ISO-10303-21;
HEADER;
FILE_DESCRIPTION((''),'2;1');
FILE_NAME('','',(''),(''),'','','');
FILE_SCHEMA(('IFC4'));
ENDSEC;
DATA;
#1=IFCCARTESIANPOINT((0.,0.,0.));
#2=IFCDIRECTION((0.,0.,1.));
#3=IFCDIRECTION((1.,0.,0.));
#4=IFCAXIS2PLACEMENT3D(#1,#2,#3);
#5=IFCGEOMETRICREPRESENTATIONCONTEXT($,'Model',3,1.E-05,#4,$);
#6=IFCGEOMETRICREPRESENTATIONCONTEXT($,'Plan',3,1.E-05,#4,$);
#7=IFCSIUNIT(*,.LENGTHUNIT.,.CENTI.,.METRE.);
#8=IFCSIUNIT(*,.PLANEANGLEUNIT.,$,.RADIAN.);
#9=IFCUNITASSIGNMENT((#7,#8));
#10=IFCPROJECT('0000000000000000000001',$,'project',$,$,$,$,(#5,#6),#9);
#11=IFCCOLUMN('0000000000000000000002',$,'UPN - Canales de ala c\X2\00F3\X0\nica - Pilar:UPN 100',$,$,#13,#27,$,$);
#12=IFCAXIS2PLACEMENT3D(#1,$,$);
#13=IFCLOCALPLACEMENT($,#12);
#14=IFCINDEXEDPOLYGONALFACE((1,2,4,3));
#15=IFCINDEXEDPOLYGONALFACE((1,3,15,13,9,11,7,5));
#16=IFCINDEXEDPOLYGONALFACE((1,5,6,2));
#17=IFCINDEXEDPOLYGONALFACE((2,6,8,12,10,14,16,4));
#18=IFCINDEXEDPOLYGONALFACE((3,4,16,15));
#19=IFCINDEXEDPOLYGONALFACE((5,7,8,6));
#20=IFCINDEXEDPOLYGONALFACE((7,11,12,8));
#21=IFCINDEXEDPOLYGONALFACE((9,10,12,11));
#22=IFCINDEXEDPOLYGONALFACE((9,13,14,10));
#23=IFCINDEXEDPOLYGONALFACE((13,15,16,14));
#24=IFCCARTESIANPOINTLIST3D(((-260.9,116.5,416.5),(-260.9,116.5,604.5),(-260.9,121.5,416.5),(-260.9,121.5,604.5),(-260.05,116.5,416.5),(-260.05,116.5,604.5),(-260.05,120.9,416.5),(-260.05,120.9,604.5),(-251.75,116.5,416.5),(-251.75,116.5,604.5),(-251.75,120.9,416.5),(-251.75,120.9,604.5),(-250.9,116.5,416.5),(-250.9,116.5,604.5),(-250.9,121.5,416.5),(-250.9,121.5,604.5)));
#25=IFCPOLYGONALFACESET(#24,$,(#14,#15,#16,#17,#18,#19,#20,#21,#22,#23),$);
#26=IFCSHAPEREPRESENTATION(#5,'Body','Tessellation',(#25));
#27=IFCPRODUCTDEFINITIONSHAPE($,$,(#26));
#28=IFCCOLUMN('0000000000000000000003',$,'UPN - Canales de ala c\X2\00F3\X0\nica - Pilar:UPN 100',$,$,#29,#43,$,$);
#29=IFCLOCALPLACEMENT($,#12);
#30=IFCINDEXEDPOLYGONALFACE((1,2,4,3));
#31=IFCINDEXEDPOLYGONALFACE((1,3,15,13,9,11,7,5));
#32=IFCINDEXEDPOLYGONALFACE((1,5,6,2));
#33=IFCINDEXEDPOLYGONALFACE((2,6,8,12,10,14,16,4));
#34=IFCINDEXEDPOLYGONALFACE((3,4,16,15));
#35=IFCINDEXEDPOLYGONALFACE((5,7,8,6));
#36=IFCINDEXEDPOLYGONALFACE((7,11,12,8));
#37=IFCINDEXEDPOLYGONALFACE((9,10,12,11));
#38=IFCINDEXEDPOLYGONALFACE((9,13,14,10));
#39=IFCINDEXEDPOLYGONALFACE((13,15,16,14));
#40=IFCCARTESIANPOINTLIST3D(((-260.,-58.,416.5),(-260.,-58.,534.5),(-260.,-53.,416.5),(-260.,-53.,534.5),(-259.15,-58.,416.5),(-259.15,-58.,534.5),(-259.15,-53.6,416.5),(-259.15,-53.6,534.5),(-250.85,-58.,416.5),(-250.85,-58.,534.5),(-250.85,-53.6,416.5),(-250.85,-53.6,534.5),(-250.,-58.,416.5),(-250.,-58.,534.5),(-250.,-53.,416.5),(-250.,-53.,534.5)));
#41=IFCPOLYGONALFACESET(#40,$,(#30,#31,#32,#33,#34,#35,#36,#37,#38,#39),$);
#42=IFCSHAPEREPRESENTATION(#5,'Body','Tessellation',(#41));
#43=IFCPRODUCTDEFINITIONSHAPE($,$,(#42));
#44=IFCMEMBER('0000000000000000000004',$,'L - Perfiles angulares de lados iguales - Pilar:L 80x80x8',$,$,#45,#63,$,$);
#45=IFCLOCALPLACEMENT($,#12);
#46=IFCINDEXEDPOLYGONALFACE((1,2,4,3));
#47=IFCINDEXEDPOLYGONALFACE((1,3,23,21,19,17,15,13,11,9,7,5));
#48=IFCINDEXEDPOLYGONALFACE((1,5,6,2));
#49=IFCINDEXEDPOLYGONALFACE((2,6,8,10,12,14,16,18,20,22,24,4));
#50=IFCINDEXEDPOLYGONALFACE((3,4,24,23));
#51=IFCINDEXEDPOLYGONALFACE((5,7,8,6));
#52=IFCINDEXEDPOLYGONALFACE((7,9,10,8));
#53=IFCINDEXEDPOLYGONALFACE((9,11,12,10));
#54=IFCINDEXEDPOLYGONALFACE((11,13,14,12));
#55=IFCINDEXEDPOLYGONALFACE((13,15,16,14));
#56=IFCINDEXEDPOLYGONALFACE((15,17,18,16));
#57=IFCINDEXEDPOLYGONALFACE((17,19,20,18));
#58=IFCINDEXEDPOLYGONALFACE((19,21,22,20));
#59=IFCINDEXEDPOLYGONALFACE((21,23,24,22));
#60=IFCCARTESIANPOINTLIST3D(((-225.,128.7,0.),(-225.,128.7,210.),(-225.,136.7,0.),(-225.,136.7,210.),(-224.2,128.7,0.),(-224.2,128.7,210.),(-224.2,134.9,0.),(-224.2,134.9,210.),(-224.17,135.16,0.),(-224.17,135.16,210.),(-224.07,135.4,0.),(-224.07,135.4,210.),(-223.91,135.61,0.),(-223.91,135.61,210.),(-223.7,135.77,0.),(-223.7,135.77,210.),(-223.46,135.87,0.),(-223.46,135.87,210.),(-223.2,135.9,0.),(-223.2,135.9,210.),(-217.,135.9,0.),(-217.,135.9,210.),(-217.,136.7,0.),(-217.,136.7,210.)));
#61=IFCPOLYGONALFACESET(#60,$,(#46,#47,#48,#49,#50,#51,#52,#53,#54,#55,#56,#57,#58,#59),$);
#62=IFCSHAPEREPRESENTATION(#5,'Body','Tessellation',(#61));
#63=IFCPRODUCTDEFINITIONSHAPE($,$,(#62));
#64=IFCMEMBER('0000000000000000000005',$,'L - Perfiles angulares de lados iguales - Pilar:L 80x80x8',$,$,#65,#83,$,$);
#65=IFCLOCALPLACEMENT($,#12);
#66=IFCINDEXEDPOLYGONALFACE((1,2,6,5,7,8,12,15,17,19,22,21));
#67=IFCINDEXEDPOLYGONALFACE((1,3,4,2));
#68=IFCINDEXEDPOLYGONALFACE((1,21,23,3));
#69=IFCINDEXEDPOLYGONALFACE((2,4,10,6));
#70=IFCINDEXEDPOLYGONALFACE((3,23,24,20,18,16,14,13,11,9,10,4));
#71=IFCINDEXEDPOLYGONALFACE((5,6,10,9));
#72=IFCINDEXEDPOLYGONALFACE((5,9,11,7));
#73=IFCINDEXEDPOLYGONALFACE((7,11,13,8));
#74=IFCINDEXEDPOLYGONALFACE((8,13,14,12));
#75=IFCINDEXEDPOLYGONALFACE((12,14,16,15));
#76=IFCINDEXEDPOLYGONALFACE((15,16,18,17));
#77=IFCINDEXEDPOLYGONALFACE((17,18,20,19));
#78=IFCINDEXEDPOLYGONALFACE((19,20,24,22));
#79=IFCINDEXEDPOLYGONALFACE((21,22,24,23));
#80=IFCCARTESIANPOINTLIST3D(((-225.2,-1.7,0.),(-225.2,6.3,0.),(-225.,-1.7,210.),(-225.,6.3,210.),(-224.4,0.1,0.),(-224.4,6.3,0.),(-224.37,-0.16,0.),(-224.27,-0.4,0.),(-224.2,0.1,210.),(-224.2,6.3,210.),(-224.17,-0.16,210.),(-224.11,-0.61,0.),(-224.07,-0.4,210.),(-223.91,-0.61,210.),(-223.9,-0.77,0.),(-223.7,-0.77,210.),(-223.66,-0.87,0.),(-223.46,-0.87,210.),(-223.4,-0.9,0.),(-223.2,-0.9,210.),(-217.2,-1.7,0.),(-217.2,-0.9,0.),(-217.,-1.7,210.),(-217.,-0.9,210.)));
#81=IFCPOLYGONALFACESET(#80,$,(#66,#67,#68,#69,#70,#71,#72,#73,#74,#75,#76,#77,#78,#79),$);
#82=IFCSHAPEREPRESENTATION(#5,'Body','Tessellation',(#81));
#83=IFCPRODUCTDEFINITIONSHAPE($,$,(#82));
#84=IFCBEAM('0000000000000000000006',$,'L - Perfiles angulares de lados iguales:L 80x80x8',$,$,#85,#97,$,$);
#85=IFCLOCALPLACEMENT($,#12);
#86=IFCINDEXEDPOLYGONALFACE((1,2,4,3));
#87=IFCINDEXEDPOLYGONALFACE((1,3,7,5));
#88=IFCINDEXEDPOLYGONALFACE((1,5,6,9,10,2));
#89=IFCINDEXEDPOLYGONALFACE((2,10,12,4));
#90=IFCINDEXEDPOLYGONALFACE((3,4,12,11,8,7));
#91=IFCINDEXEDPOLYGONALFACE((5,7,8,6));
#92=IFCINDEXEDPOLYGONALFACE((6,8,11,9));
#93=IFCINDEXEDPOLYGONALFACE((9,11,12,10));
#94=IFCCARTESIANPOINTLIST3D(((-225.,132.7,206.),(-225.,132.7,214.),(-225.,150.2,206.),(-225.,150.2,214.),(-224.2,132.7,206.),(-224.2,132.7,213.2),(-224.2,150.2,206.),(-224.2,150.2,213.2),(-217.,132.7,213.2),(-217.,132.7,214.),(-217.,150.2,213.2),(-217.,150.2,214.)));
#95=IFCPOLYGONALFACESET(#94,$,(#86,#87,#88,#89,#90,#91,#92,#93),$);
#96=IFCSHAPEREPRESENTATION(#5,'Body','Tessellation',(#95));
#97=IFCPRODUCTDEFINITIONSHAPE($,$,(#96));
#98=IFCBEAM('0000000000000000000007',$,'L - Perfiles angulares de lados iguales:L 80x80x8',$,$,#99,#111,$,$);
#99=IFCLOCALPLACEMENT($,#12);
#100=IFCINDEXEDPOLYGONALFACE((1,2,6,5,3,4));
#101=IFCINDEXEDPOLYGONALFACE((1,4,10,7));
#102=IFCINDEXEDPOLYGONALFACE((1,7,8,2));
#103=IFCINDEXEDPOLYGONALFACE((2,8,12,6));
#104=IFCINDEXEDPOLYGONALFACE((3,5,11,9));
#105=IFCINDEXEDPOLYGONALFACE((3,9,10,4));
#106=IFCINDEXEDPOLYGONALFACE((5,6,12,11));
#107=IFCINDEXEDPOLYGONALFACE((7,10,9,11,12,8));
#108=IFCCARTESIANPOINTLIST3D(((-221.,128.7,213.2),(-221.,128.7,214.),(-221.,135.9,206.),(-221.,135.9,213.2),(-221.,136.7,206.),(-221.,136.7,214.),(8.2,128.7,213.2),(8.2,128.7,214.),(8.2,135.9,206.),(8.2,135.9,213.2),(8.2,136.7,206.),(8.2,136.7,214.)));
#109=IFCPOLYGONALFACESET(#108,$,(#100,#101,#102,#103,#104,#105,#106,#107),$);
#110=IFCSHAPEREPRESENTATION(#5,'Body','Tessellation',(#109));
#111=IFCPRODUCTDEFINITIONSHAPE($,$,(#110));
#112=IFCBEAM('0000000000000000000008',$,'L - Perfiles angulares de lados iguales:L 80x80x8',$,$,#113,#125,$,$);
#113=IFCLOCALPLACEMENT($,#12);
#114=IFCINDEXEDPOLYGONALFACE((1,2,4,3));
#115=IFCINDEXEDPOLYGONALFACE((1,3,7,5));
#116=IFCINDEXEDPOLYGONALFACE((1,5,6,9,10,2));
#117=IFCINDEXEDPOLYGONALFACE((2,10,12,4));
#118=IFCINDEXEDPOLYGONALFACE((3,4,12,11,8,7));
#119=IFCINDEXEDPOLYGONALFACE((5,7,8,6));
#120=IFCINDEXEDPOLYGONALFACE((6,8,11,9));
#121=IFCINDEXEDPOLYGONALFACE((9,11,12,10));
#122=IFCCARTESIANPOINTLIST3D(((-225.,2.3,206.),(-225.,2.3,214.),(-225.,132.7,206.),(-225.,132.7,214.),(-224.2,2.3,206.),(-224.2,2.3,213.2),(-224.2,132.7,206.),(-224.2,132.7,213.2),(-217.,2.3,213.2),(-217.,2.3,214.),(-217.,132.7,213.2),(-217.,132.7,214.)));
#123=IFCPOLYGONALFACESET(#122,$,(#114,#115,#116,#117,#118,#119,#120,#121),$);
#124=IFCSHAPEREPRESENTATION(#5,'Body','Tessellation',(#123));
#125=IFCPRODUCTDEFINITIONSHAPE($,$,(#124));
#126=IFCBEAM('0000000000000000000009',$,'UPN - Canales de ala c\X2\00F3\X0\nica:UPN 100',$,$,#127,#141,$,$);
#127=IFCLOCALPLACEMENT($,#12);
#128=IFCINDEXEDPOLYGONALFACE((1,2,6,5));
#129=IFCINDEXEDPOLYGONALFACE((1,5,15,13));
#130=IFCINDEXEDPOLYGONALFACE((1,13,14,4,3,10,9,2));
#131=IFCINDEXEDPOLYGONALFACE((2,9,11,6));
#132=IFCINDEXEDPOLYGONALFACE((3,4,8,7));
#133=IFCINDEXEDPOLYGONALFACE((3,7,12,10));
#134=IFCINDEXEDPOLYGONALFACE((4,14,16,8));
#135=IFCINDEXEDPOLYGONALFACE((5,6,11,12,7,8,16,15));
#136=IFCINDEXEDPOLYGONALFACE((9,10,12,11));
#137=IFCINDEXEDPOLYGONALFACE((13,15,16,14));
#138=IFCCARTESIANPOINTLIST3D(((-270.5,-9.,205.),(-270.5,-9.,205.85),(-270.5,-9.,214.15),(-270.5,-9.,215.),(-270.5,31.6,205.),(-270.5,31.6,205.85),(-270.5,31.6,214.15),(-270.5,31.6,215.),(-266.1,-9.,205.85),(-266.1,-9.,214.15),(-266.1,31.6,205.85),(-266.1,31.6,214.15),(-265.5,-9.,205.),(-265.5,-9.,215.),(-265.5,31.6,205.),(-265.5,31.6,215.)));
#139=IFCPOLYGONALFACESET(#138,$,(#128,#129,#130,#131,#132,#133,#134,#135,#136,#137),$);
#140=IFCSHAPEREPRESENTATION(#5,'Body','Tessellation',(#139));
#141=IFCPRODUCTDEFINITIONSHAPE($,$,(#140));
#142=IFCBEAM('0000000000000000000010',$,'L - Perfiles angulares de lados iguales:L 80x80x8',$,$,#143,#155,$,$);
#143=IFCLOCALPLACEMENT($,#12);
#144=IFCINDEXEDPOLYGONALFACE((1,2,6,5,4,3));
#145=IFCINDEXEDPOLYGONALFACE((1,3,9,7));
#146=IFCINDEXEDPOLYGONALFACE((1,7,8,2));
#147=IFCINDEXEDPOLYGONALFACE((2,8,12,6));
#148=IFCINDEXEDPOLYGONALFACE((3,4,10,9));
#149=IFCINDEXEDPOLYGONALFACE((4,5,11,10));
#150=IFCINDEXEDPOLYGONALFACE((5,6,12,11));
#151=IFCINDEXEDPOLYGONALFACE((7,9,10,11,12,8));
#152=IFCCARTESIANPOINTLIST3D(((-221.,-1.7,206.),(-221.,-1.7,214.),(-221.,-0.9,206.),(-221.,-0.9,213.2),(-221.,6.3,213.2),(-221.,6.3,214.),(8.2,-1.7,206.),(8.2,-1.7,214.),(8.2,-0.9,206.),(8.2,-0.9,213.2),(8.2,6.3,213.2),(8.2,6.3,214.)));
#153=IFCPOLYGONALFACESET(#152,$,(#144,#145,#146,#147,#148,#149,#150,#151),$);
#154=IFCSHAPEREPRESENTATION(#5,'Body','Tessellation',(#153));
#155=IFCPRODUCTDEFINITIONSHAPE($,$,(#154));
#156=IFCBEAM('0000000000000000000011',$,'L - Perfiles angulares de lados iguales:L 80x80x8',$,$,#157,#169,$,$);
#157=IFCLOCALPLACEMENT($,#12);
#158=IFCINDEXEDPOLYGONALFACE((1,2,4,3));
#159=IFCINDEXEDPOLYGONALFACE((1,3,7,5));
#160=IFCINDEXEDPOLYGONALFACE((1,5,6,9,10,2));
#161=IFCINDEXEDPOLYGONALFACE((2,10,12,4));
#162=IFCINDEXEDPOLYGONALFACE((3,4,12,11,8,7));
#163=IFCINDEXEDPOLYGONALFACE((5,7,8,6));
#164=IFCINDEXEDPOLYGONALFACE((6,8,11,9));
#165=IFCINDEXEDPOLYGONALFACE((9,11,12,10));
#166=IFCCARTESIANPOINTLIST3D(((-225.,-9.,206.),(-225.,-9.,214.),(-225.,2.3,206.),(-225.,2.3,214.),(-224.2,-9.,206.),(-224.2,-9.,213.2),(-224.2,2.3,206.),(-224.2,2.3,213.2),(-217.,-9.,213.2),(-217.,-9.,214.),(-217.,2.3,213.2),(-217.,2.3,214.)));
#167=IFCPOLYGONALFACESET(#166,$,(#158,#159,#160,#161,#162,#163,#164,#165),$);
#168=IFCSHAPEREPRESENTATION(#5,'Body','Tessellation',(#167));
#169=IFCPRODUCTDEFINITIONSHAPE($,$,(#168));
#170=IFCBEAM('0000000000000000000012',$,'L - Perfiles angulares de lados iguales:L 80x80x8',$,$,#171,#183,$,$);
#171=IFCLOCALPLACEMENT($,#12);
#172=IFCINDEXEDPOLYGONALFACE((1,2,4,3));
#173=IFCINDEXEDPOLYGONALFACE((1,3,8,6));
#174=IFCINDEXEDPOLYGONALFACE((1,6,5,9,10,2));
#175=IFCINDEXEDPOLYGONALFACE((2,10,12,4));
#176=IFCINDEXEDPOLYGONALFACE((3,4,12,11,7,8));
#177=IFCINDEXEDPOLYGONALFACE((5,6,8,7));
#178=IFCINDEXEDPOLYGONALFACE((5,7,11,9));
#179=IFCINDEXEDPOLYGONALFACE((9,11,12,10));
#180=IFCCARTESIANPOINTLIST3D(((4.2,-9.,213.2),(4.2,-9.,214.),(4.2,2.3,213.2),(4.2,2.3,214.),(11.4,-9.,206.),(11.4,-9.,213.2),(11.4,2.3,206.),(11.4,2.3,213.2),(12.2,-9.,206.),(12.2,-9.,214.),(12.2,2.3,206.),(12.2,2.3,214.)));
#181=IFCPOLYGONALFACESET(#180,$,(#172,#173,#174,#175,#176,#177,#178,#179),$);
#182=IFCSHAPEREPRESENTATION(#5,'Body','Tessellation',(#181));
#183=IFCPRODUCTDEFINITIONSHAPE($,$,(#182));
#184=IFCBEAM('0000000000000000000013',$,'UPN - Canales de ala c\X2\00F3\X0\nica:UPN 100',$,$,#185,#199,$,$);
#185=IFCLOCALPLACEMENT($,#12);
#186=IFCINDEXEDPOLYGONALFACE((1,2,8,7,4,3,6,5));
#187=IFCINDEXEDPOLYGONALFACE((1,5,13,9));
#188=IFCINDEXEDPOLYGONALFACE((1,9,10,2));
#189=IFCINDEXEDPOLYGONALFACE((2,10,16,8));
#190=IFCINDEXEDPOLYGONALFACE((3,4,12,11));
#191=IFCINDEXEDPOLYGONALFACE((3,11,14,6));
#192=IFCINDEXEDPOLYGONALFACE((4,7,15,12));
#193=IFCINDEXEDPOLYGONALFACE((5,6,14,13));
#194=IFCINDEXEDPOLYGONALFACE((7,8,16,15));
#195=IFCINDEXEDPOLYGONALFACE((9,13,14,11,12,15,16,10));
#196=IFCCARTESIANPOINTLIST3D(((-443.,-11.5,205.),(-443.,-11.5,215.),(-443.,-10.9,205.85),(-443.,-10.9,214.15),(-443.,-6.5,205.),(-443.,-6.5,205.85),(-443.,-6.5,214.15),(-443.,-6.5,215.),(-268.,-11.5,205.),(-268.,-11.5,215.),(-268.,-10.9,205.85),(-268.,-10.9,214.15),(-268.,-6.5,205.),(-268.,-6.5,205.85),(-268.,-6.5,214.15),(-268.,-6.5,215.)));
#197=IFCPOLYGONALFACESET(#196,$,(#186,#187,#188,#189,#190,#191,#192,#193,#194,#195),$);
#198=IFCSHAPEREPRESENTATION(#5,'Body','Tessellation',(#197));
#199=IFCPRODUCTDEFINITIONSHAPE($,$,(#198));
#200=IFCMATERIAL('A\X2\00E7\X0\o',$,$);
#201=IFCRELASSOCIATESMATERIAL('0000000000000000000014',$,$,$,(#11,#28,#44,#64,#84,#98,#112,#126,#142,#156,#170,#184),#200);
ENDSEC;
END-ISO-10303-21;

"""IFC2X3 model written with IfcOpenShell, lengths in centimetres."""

from ifc_helpers import new_model, si_unit, frame, frame_2d, origin_with_axes, origin_2d_with_axis, place, context, project, polyline, l_section, u_section, outline, extrude, material, element, save


model = new_model("IFC2X3")

# Units and contexts
model_context = context("Model", 3, precision=1e-05, world=origin_with_axes())
plan_context = context("Plan", 3, precision=1e-05, world=origin_with_axes())
ifc_project = project(units=[si_unit("LENGTHUNIT", "METRE", prefix="CENTI"), si_unit("PLANEANGLEUNIT", "RADIAN")], contexts=[model_context, plan_context])

# Columns
ifc_material = material(Name="Aço")
column_1_placement = place(None, frame((-255.9, 119.0, 416.5), z_axis=(0.0, 0.0, 1.0), x_axis=(0.0, -1.0, 0.0)))
element("IfcColumn", 1, at=column_1_placement, material=ifc_material, Name="UPN - Canales de ala cónica - Pilar:UPN 100", context=model_context, shape_type="SweptSolid", body=[
    extrude(u_section(Depth=10.0, FlangeWidth=5.0, WebThickness=0.6, FlangeThickness=0.85, FilletRadius=0.0, EdgeRadius=0.0, FlangeSlope=0.0, CentreOfGravityInX=0.0, at=frame_2d((0.0, 0.0), x_axis=(1.0, 0.0))), origin_with_axes(), (0.0, 0.0, 1.0), 188.0),
])
column_2_placement = place(None, frame((-255.0, -55.5, 416.5), z_axis=(0.0, 0.0, 1.0), x_axis=(0.0, -1.0, 0.0)))
element("IfcColumn", 2, at=column_2_placement, material=ifc_material, Name="UPN - Canales de ala cónica - Pilar:UPN 100", context=model_context, shape_type="SweptSolid", body=[
    extrude(u_section(Depth=10.0, FlangeWidth=5.0, WebThickness=0.6, FlangeThickness=0.85, FilletRadius=0.0, EdgeRadius=0.0, FlangeSlope=0.0, CentreOfGravityInX=0.0, at=origin_2d_with_axis()), origin_with_axes(), (0.0, 0.0, 1.0), 118.0),
])

# Members
member_1_placement = place(None, frame((-221.0, 132.7, 0.0), z_axis=(0.0, 0.0, 1.0), x_axis=(0.0, -1.0, 0.0)))
element("IfcMember", 3, at=member_1_placement, material=ifc_material, Name="L - Perfiles angulares de lados iguales - Pilar:L 80x80x8", context=model_context, shape_type="SweptSolid", body=[
    extrude(l_section(Depth=8.0, Width=8.0, Thickness=0.8, FilletRadius=1.0, EdgeRadius=0.0, LegSlope=0.0, CentreOfGravityInX=0.0, CentreOfGravityInY=0.0, at=origin_2d_with_axis()), origin_with_axes(), (0.0, 0.0, 1.0), 210.0),
])
member_2_placement = place(None, frame((-221.2, 2.3, 0.0), z_axis=(0.000952, 0.0, 1.0), x_axis=(1.0, 0.0, -0.000952)))
element("IfcMember", 4, at=member_2_placement, material=ifc_material, Name="L - Perfiles angulares de lados iguales - Pilar:L 80x80x8", context=model_context, shape_type="SweptSolid", body=[
    extrude(l_section(Depth=8.0, Width=8.0, Thickness=0.8, FilletRadius=1.0, EdgeRadius=0.0, LegSlope=0.0, CentreOfGravityInX=0.0, CentreOfGravityInY=0.0, at=frame_2d((0.0, 0.0), x_axis=(1.0, 0.0))), origin_with_axes(), (0.0, 0.0, 1.0), 210.0),
])

# Beams
beam_1_placement = place(None, frame((-221.0, 132.7, 210.0), z_axis=(0.0, 1.0, 0.0), x_axis=(-1.0, 0.0, 0.0)))
element("IfcBeam", 5, at=beam_1_placement, material=ifc_material, Name="L - Perfiles angulares de lados iguales:L 80x80x8", context=model_context, shape_type="SweptSolid", body=[
    extrude(outline(polyline([(4.0, -4.0), (4.0, 4.0), (-4.0, 4.0), (-4.0, 3.2), (3.2, 3.2), (3.2, -4.0), (4.0, -4.0)])), origin_with_axes(), (0.0, 0.0, 1.0), 17.5),
])
beam_2_placement = place(None, frame((8.2, 132.7, 210.0), z_axis=(-1.0, 0.0, 0.0), x_axis=(0.0, 0.0, 1.0)))
element("IfcBeam", 6, at=beam_2_placement, material=ifc_material, Name="L - Perfiles angulares de lados iguales:L 80x80x8", context=model_context, shape_type="SweptSolid", body=[
    extrude(outline(polyline([(4.0, -4.0), (4.0, 4.0), (-4.0, 4.0), (-4.0, 3.2), (3.2, 3.2), (3.2, -4.0), (4.0, -4.0)])), origin_with_axes(), (0.0, 0.0, 1.0), 229.2),
])
beam_3_placement = place(None, frame((-221.0, 2.3, 210.0), z_axis=(0.0, 1.0, 0.0), x_axis=(-1.0, 0.0, 0.0)))
element("IfcBeam", 7, at=beam_3_placement, material=ifc_material, Name="L - Perfiles angulares de lados iguales:L 80x80x8", context=model_context, shape_type="SweptSolid", body=[
    extrude(outline(polyline([(4.0, -4.0), (4.0, 4.0), (-4.0, 4.0), (-4.0, 3.2), (3.2, 3.2), (3.2, -4.0), (4.0, -4.0)])), origin_with_axes(), (0.0, 0.0, 1.0), 130.4),
])
beam_4_placement = place(None, frame((-268.0, -9.0, 210.0), z_axis=(0.0, 1.0, 0.0), x_axis=(-1.0, 0.0, 0.0)))
element("IfcBeam", 8, at=beam_4_placement, material=ifc_material, Name="UPN - Canales de ala cónica:UPN 100", context=model_context, shape_type="SweptSolid", body=[
    extrude(u_section(Depth=10.0, FlangeWidth=5.0, WebThickness=0.6, FlangeThickness=0.85, FilletRadius=0.0, EdgeRadius=0.0, FlangeSlope=0.0, CentreOfGravityInX=0.0, at=origin_2d_with_axis()), origin_with_axes(), (0.0, 0.0, 1.0), 40.6),
])
beam_5_placement = place(None, frame((8.2, 2.3, 210.0), z_axis=(-1.0, 0.0, 0.0), x_axis=(0.0, -1.0, 0.0)))
element("IfcBeam", 9, at=beam_5_placement, material=ifc_material, Name="L - Perfiles angulares de lados iguales:L 80x80x8", context=model_context, shape_type="SweptSolid", body=[
    extrude(outline(polyline([(4.0, -4.0), (4.0, 4.0), (-4.0, 4.0), (-4.0, 3.2), (3.2, 3.2), (3.2, -4.0), (4.0, -4.0)])), origin_with_axes(), (0.0, 0.0, 1.0), 229.2),
])
beam_6_placement = place(None, frame((-221.0, -9.0, 210.0), z_axis=(0.0, 1.0, 0.0), x_axis=(-1.0, 0.0, 0.0)))
element("IfcBeam", 10, at=beam_6_placement, material=ifc_material, Name="L - Perfiles angulares de lados iguales:L 80x80x8", context=model_context, shape_type="SweptSolid", body=[
    extrude(outline(polyline([(4.0, -4.0), (4.0, 4.0), (-4.0, 4.0), (-4.0, 3.2), (3.2, 3.2), (3.2, -4.0), (4.0, -4.0)])), origin_with_axes(), (0.0, 0.0, 1.0), 11.3),
])
beam_7_placement = place(None, frame((8.2, -9.0, 210.0), z_axis=(0.0, 1.0, 0.0), x_axis=(0.0, 0.0, 1.0)))
element("IfcBeam", 11, at=beam_7_placement, material=ifc_material, Name="L - Perfiles angulares de lados iguales:L 80x80x8", context=model_context, shape_type="SweptSolid", body=[
    extrude(outline(polyline([(4.0, -4.0), (4.0, 4.0), (-4.0, 4.0), (-4.0, 3.2), (3.2, 3.2), (3.2, -4.0), (4.0, -4.0)])), origin_with_axes(), (0.0, 0.0, 1.0), 11.3),
])
beam_8_placement = place(None, frame((-268.0, -9.0, 210.0), z_axis=(-1.0, 0.0, 0.0), x_axis=(0.0, 1.0, 0.0)))
element("IfcBeam", 12, at=beam_8_placement, material=ifc_material, Name="UPN - Canales de ala cónica:UPN 100", context=model_context, shape_type="SweptSolid", body=[
    extrude(u_section(Depth=10.0, FlangeWidth=5.0, WebThickness=0.6, FlangeThickness=0.85, FilletRadius=0.0, EdgeRadius=0.0, FlangeSlope=0.0, CentreOfGravityInX=0.0, at=frame_2d((0.0, 0.0), x_axis=(1.0, 0.0))), origin_with_axes(), (0.0, 0.0, 1.0), 175.0),
])

save(model, "model.ifc")
